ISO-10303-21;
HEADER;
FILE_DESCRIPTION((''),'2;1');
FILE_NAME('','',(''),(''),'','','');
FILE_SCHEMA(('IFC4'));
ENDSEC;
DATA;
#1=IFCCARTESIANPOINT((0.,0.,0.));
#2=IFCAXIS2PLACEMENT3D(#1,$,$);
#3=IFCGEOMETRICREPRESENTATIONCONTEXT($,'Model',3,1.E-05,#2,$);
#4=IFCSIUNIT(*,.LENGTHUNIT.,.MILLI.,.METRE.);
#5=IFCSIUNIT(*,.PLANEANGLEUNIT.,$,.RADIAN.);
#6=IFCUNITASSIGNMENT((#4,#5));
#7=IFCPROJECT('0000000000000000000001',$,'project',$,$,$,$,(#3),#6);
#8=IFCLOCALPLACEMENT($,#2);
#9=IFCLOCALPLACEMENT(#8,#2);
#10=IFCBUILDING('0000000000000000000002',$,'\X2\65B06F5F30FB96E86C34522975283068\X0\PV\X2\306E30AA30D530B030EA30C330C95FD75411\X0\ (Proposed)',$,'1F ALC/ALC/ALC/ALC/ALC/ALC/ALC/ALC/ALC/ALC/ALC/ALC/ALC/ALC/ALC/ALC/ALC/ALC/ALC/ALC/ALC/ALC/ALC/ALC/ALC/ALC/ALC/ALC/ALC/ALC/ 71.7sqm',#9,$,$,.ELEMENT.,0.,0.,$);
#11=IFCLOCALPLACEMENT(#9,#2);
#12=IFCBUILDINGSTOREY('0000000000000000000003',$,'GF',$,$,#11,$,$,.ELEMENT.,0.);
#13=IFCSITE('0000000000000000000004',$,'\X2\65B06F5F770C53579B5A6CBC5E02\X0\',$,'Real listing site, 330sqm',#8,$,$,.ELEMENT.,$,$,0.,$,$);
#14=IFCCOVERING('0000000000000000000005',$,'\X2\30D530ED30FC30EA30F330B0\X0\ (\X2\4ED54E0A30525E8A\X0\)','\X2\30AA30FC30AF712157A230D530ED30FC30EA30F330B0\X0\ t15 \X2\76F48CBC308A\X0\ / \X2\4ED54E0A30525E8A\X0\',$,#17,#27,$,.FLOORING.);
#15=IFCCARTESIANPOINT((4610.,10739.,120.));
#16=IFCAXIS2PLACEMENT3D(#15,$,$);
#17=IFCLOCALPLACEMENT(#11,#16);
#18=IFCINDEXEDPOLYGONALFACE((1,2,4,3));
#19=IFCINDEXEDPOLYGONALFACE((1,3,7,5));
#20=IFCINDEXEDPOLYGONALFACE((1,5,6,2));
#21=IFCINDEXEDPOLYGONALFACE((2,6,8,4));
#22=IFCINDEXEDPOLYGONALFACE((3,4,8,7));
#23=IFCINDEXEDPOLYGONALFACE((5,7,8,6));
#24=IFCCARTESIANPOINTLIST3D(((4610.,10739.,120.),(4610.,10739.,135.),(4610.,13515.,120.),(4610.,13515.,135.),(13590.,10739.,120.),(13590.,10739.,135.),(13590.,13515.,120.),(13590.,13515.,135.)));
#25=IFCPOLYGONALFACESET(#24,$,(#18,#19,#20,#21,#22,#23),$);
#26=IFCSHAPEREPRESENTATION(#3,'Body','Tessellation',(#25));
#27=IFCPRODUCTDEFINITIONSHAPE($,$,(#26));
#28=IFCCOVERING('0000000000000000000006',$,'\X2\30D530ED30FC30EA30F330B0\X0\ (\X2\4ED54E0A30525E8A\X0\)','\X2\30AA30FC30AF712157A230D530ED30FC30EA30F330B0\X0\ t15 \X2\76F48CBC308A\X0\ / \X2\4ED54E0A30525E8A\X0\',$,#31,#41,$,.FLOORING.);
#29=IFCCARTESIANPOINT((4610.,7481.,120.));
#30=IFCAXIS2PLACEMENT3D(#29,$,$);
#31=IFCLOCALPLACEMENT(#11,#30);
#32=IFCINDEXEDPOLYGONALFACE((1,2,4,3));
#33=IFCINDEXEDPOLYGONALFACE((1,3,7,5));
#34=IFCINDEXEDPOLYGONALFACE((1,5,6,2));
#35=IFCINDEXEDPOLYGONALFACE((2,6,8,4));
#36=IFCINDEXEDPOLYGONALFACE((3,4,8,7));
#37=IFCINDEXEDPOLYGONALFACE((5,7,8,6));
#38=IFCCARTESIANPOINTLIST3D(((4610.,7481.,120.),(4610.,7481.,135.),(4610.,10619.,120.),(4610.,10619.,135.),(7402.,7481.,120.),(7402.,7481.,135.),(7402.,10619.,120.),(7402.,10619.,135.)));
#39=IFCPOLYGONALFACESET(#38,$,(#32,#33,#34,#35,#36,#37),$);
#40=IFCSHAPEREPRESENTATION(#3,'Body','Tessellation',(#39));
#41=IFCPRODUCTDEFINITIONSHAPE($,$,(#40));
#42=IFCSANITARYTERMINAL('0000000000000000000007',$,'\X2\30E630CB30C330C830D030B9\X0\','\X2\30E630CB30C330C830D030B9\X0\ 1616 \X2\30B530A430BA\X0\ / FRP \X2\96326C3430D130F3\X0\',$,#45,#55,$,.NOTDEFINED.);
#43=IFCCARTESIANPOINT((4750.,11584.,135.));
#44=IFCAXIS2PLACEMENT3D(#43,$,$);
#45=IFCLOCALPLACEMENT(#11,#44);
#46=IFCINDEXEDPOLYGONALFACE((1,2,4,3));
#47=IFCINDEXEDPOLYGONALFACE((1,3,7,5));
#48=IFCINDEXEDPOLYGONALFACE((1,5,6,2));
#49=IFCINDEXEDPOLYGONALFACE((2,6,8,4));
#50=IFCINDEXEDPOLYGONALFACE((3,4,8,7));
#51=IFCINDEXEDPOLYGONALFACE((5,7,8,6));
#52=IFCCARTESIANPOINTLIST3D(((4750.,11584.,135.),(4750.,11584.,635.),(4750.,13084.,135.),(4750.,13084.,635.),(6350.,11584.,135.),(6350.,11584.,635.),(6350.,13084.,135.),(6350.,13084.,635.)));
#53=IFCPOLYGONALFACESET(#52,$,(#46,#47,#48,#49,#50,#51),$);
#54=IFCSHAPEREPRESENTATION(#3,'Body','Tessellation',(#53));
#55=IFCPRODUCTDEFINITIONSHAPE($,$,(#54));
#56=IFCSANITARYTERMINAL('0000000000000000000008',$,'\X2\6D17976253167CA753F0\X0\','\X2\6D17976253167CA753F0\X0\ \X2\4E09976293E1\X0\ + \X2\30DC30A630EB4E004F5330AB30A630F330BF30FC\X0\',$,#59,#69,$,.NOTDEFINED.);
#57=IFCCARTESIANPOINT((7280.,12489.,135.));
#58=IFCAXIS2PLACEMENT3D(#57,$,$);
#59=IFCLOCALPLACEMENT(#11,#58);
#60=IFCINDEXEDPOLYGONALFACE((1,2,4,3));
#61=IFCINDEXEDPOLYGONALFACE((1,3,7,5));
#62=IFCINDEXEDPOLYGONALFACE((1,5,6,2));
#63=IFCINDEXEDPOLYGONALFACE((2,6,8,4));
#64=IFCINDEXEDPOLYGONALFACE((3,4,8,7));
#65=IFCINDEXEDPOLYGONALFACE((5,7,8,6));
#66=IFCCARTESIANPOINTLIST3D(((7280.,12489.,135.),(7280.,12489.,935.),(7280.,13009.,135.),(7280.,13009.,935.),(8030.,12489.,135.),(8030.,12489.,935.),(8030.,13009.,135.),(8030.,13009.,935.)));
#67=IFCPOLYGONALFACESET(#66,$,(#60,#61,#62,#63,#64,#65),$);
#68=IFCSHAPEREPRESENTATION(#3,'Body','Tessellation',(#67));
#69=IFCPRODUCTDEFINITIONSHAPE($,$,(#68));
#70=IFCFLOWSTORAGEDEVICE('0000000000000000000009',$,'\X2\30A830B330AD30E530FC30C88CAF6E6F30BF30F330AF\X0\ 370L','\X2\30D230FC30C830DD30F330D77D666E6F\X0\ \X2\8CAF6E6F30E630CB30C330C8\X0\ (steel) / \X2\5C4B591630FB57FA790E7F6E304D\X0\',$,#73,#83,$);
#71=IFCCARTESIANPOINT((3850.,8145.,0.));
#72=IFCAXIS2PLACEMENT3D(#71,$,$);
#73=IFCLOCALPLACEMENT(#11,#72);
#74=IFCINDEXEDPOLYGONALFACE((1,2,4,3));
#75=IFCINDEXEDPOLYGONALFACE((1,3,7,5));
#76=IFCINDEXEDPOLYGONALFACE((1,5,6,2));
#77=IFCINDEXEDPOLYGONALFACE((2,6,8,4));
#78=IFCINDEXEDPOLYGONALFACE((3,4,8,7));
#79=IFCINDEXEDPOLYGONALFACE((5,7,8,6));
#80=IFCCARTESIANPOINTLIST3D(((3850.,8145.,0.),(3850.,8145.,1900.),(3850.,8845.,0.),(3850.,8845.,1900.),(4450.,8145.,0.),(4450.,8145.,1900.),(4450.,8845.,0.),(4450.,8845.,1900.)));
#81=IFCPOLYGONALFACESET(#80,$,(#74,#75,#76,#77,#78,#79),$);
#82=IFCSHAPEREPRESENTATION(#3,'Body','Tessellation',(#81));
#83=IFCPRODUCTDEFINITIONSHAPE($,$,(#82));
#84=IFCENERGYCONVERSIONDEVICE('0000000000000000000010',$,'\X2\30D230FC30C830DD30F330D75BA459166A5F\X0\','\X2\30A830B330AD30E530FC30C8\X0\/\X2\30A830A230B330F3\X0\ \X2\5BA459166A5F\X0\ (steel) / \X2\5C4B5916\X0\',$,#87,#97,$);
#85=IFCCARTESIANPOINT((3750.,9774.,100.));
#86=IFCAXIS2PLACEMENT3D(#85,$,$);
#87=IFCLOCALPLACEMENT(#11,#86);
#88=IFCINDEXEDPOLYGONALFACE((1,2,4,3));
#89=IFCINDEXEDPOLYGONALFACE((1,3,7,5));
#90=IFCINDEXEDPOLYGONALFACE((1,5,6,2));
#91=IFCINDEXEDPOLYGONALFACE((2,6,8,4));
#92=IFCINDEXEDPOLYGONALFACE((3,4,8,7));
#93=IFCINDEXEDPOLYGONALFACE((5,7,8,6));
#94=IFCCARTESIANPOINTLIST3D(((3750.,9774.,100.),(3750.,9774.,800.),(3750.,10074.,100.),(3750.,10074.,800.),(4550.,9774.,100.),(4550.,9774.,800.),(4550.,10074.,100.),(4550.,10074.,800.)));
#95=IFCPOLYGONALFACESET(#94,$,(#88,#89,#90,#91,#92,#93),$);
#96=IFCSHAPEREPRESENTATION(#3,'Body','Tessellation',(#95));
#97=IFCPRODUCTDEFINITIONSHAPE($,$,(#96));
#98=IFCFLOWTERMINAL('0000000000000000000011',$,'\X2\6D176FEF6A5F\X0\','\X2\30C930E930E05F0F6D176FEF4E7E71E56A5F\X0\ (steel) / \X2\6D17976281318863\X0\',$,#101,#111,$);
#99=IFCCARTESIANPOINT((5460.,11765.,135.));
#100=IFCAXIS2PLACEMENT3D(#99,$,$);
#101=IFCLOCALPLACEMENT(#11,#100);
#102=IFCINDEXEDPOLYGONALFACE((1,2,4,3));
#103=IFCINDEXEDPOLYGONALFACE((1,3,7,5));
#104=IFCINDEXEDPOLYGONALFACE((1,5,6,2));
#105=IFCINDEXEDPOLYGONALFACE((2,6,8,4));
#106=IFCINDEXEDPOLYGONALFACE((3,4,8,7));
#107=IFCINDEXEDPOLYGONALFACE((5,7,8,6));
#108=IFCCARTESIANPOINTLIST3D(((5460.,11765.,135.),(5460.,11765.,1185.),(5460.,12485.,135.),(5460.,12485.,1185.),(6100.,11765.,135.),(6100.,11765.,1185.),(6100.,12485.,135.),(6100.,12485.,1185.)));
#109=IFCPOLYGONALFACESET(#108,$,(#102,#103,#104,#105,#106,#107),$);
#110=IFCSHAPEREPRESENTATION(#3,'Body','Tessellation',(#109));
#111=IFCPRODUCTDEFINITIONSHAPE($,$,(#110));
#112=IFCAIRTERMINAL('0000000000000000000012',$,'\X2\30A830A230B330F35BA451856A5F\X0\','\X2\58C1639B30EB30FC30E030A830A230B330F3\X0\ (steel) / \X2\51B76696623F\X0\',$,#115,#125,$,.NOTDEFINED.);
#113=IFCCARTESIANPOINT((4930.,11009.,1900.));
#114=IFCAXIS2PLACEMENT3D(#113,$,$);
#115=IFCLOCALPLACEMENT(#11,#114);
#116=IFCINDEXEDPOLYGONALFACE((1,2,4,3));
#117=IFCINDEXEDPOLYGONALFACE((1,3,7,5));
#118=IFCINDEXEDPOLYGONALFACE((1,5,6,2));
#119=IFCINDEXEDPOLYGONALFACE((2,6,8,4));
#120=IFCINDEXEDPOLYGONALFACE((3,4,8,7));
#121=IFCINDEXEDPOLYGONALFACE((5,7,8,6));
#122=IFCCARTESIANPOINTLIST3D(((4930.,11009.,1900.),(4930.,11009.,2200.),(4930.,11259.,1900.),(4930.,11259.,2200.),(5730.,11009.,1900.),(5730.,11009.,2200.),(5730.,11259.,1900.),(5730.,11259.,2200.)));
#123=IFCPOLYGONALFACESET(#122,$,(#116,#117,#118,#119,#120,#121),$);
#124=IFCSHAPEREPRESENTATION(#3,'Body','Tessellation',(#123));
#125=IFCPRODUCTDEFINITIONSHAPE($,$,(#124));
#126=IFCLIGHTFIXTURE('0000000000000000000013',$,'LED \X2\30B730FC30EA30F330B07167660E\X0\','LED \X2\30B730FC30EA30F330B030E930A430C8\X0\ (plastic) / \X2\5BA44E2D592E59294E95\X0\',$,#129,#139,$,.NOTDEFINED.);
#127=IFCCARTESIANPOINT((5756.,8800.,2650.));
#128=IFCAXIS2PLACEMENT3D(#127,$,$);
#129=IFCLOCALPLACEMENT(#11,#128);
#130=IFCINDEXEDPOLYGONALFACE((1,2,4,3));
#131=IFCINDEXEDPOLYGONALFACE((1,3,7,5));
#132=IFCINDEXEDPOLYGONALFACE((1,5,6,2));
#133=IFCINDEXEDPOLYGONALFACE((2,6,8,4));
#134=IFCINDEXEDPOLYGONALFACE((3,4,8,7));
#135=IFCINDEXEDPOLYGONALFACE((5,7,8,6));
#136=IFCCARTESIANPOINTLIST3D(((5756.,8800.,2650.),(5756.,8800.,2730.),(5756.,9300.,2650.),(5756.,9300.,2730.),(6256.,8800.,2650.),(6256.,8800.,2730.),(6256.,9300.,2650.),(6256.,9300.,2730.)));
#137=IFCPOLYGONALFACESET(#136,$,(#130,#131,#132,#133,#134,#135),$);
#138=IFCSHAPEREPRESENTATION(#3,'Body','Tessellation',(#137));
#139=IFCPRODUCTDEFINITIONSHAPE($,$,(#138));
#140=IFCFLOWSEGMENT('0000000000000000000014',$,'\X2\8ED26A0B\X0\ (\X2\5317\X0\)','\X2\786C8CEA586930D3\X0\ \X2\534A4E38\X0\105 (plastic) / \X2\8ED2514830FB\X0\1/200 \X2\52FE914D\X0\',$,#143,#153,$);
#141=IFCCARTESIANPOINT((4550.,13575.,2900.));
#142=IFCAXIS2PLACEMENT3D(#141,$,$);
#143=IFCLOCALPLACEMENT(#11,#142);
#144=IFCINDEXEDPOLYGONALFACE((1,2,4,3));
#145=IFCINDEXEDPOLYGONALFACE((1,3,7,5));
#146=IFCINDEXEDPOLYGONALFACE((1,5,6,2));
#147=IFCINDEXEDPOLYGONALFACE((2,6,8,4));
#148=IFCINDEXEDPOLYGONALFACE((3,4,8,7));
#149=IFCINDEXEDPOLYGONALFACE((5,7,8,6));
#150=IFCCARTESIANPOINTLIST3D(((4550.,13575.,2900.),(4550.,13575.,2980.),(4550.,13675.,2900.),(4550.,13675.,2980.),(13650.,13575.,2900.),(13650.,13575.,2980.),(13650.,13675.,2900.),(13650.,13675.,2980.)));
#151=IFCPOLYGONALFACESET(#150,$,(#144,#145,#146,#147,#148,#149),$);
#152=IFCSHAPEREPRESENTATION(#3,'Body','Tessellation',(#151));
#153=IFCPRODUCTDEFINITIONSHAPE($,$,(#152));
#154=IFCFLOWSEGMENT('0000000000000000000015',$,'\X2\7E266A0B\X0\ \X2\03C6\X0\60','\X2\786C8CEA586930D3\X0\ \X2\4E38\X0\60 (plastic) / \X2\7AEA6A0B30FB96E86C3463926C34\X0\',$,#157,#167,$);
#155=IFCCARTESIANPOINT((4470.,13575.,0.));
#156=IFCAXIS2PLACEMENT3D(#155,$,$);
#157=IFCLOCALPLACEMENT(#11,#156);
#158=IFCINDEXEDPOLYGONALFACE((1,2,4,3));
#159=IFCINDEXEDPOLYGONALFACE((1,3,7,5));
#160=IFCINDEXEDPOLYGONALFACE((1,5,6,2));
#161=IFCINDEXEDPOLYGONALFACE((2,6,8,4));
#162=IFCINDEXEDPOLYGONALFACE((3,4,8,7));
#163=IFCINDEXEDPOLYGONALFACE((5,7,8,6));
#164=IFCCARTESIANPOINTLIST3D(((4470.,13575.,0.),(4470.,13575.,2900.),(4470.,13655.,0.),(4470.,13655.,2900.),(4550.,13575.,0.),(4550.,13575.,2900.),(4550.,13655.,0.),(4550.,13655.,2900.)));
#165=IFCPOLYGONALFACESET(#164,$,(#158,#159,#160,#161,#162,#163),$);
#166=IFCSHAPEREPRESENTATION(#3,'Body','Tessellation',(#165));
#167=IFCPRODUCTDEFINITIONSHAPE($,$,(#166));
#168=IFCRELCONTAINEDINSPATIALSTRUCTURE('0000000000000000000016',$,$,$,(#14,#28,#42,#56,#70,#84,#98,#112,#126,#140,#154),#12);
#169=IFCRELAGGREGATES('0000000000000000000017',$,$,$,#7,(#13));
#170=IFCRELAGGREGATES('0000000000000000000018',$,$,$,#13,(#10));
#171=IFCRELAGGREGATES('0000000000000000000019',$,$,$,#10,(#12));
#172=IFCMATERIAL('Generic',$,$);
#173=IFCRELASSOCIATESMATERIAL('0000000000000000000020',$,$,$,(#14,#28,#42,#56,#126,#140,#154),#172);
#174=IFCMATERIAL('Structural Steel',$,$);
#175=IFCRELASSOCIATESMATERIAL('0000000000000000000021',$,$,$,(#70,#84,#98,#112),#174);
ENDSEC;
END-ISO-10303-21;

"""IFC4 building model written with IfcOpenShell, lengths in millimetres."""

from ifc_helpers import new_model, si_unit, frame, frame_2d, origin, place, context, project, spatial, rectangle, extrude, material, element, save


model = new_model("IFC4")

# Units and contexts
model_context = context("Model", 3, precision=1e-05, world=origin())
ifc_project = project(units=[si_unit("LENGTHUNIT", "METRE", prefix="MILLI"), si_unit("PLANEANGLEUNIT", "RADIAN")], contexts=[model_context])

# Site, building, storey
site_placement = place(None, origin())
site = spatial("IfcSite", under=ifc_project, at=site_placement, Name="新潟県南魚沼市", ObjectType="Real listing site, 330sqm", CompositionType="ELEMENT", RefElevation=0.0)
building_placement = place(site_placement, origin())
building = spatial("IfcBuilding", under=site, at=building_placement, Name="新潟・雨水利用とPVのオフグリッド志向 (Proposed)", ObjectType="1F ALC/ALC/ALC/ALC/ALC/ALC/ALC/ALC/ALC/ALC/ALC/ALC/ALC/ALC/ALC/ALC/ALC/ALC/ALC/ALC/ALC/ALC/ALC/ALC/ALC/ALC/ALC/ALC/ALC/ALC/ 71.7sqm", CompositionType="ELEMENT", ElevationOfRefHeight=0.0, ElevationOfTerrain=0.0)
storey_placement = place(building_placement, origin())
storey = spatial("IfcBuildingStorey", under=building, at=storey_placement, Name="GF", CompositionType="ELEMENT", Elevation=0.0)

# Shared definitions
ifc_material_1 = material(Name="Structural Steel")

# Coverings
ifc_material_2 = material(Name="Generic")
covering_1_placement = place(storey_placement, frame((4610.0, 10739.0, 120.0)))
element("IfcCovering", 1, at=covering_1_placement, inside=storey, material=ifc_material_2, Name="フローリング (仕上げ床)", Description="オーク無垢フローリング t15 直貼り / 仕上げ床", PredefinedType="FLOORING", context=model_context, shape_type="SweptSolid", body=[
    extrude(rectangle(XDim=8980.0, YDim=2776.0, at=frame_2d((4490.0, 1388.0))), frame((4610.0, 10739.0, 120.0)), (0.0, 0.0, 1.0), 15.0),
])
covering_2_placement = place(storey_placement, frame((4610.0, 7481.0, 120.0)))
element("IfcCovering", 2, at=covering_2_placement, inside=storey, material=ifc_material_2, Name="フローリング (仕上げ床)", Description="オーク無垢フローリング t15 直貼り / 仕上げ床", PredefinedType="FLOORING", context=model_context, shape_type="SweptSolid", body=[
    extrude(rectangle(XDim=2792.0, YDim=3138.0, at=frame_2d((1396.0, 1569.0))), frame((4610.0, 7481.0, 120.0)), (0.0, 0.0, 1.0), 15.0),
])

# Sanitary terminals
sanitary_terminal_1_placement = place(storey_placement, frame((4750.0, 11584.0, 135.0)))
element("IfcSanitaryTerminal", 3, at=sanitary_terminal_1_placement, inside=storey, material=ifc_material_2, Name="ユニットバス", Description="ユニットバス 1616 サイズ / FRP 防水パン", PredefinedType="NOTDEFINED", context=model_context, shape_type="SweptSolid", body=[
    extrude(rectangle(XDim=1600.0, YDim=1500.0, at=frame_2d((800.0, 750.0))), frame((4750.0, 11584.0, 135.0)), (0.0, 0.0, 1.0), 500.0),
])
sanitary_terminal_2_placement = place(storey_placement, frame((7280.0, 12489.0, 135.0)))
element("IfcSanitaryTerminal", 4, at=sanitary_terminal_2_placement, inside=storey, material=ifc_material_2, Name="洗面化粧台", Description="洗面化粧台 三面鏡 + ボウル一体カウンター", PredefinedType="NOTDEFINED", context=model_context, shape_type="SweptSolid", body=[
    extrude(rectangle(XDim=750.0, YDim=520.0, at=frame_2d((375.0, 260.0))), frame((7280.0, 12489.0, 135.0)), (0.0, 0.0, 1.0), 800.0),
])

# Flow storage device
flow_storage_device_placement = place(storey_placement, frame((3850.0, 8145.0, 0.0)))
element("IfcFlowStorageDevice", 5, at=flow_storage_device_placement, inside=storey, material=ifc_material_1, Name="エコキュート貯湯タンク 370L", Description="ヒートポンプ給湯 貯湯ユニット (steel) / 屋外・基礎置き", context=model_context, shape_type="SweptSolid", body=[
    extrude(rectangle(XDim=600.0, YDim=700.0, at=frame_2d((300.0, 350.0))), frame((3850.0, 8145.0, 0.0)), (0.0, 0.0, 1.0), 1900.0),
])

# Energy conversion device
energy_conversion_device_placement = place(storey_placement, frame((3750.0, 9774.0, 100.0)))
element("IfcEnergyConversionDevice", 6, at=energy_conversion_device_placement, inside=storey, material=ifc_material_1, Name="ヒートポンプ室外機", Description="エコキュート/エアコン 室外機 (steel) / 屋外", context=model_context, shape_type="SweptSolid", body=[
    extrude(rectangle(XDim=800.0, YDim=300.0, at=frame_2d((400.0, 150.0))), frame((3750.0, 9774.0, 100.0)), (0.0, 0.0, 1.0), 700.0),
])

# Flow terminal
flow_terminal_placement = place(storey_placement, frame((5460.0, 11765.0, 135.0)))
element("IfcFlowTerminal", 7, at=flow_terminal_placement, inside=storey, material=ifc_material_1, Name="洗濯機", Description="ドラム式洗濯乾燥機 (steel) / 洗面脱衣", context=model_context, shape_type="SweptSolid", body=[
    extrude(rectangle(XDim=640.0, YDim=720.0, at=frame_2d((320.0, 360.0))), frame((5460.0, 11765.0, 135.0)), (0.0, 0.0, 1.0), 1050.0),
])

# Air terminal
air_terminal_placement = place(storey_placement, frame((4930.0, 11009.0, 1900.0)))
element("IfcAirTerminal", 8, at=air_terminal_placement, inside=storey, material=ifc_material_1, Name="エアコン室内機", Description="壁掛ルームエアコン (steel) / 冷暖房", PredefinedType="NOTDEFINED", context=model_context, shape_type="SweptSolid", body=[
    extrude(rectangle(XDim=800.0, YDim=250.0, at=frame_2d((400.0, 125.0))), frame((4930.0, 11009.0, 1900.0)), (0.0, 0.0, 1.0), 300.0),
])

# Light fixture
light_fixture_placement = place(storey_placement, frame((5756.0, 8800.0, 2650.0)))
element("IfcLightFixture", 9, at=light_fixture_placement, inside=storey, material=ifc_material_2, Name="LED シーリング照明", Description="LED シーリングライト (plastic) / 室中央天井", PredefinedType="NOTDEFINED", context=model_context, shape_type="SweptSolid", body=[
    extrude(rectangle(XDim=500.0, YDim=500.0, at=frame_2d((250.0, 250.0))), frame((5756.0, 8800.0, 2650.0)), (0.0, 0.0, 1.0), 80.0),
])

# Flow segments
flow_segment_1_placement = place(storey_placement, frame((4550.0, 13575.0, 2900.0)))
element("IfcFlowSegment", 10, at=flow_segment_1_placement, inside=storey, material=ifc_material_2, Name="軒樋 (北)", Description="硬質塩ビ 半丸105 (plastic) / 軒先・1/200 勾配", context=model_context, shape_type="SweptSolid", body=[
    extrude(rectangle(XDim=9100.0, YDim=100.0, at=frame_2d((4550.0, 50.0))), frame((4550.0, 13575.0, 2900.0)), (0.0, 0.0, 1.0), 80.0),
])
flow_segment_2_placement = place(storey_placement, frame((4470.0, 13575.0, 0.0)))
element("IfcFlowSegment", 11, at=flow_segment_2_placement, inside=storey, material=ifc_material_2, Name="縦樋 φ60", Description="硬質塩ビ 丸60 (plastic) / 竪樋・雨水排水", context=model_context, shape_type="SweptSolid", body=[
    extrude(rectangle(XDim=80.0, YDim=80.0, at=frame_2d((40.0, 40.0))), frame((4470.0, 13575.0, 0.0)), (0.0, 0.0, 1.0), 2900.0),
])

save(model, "model.ifc")
